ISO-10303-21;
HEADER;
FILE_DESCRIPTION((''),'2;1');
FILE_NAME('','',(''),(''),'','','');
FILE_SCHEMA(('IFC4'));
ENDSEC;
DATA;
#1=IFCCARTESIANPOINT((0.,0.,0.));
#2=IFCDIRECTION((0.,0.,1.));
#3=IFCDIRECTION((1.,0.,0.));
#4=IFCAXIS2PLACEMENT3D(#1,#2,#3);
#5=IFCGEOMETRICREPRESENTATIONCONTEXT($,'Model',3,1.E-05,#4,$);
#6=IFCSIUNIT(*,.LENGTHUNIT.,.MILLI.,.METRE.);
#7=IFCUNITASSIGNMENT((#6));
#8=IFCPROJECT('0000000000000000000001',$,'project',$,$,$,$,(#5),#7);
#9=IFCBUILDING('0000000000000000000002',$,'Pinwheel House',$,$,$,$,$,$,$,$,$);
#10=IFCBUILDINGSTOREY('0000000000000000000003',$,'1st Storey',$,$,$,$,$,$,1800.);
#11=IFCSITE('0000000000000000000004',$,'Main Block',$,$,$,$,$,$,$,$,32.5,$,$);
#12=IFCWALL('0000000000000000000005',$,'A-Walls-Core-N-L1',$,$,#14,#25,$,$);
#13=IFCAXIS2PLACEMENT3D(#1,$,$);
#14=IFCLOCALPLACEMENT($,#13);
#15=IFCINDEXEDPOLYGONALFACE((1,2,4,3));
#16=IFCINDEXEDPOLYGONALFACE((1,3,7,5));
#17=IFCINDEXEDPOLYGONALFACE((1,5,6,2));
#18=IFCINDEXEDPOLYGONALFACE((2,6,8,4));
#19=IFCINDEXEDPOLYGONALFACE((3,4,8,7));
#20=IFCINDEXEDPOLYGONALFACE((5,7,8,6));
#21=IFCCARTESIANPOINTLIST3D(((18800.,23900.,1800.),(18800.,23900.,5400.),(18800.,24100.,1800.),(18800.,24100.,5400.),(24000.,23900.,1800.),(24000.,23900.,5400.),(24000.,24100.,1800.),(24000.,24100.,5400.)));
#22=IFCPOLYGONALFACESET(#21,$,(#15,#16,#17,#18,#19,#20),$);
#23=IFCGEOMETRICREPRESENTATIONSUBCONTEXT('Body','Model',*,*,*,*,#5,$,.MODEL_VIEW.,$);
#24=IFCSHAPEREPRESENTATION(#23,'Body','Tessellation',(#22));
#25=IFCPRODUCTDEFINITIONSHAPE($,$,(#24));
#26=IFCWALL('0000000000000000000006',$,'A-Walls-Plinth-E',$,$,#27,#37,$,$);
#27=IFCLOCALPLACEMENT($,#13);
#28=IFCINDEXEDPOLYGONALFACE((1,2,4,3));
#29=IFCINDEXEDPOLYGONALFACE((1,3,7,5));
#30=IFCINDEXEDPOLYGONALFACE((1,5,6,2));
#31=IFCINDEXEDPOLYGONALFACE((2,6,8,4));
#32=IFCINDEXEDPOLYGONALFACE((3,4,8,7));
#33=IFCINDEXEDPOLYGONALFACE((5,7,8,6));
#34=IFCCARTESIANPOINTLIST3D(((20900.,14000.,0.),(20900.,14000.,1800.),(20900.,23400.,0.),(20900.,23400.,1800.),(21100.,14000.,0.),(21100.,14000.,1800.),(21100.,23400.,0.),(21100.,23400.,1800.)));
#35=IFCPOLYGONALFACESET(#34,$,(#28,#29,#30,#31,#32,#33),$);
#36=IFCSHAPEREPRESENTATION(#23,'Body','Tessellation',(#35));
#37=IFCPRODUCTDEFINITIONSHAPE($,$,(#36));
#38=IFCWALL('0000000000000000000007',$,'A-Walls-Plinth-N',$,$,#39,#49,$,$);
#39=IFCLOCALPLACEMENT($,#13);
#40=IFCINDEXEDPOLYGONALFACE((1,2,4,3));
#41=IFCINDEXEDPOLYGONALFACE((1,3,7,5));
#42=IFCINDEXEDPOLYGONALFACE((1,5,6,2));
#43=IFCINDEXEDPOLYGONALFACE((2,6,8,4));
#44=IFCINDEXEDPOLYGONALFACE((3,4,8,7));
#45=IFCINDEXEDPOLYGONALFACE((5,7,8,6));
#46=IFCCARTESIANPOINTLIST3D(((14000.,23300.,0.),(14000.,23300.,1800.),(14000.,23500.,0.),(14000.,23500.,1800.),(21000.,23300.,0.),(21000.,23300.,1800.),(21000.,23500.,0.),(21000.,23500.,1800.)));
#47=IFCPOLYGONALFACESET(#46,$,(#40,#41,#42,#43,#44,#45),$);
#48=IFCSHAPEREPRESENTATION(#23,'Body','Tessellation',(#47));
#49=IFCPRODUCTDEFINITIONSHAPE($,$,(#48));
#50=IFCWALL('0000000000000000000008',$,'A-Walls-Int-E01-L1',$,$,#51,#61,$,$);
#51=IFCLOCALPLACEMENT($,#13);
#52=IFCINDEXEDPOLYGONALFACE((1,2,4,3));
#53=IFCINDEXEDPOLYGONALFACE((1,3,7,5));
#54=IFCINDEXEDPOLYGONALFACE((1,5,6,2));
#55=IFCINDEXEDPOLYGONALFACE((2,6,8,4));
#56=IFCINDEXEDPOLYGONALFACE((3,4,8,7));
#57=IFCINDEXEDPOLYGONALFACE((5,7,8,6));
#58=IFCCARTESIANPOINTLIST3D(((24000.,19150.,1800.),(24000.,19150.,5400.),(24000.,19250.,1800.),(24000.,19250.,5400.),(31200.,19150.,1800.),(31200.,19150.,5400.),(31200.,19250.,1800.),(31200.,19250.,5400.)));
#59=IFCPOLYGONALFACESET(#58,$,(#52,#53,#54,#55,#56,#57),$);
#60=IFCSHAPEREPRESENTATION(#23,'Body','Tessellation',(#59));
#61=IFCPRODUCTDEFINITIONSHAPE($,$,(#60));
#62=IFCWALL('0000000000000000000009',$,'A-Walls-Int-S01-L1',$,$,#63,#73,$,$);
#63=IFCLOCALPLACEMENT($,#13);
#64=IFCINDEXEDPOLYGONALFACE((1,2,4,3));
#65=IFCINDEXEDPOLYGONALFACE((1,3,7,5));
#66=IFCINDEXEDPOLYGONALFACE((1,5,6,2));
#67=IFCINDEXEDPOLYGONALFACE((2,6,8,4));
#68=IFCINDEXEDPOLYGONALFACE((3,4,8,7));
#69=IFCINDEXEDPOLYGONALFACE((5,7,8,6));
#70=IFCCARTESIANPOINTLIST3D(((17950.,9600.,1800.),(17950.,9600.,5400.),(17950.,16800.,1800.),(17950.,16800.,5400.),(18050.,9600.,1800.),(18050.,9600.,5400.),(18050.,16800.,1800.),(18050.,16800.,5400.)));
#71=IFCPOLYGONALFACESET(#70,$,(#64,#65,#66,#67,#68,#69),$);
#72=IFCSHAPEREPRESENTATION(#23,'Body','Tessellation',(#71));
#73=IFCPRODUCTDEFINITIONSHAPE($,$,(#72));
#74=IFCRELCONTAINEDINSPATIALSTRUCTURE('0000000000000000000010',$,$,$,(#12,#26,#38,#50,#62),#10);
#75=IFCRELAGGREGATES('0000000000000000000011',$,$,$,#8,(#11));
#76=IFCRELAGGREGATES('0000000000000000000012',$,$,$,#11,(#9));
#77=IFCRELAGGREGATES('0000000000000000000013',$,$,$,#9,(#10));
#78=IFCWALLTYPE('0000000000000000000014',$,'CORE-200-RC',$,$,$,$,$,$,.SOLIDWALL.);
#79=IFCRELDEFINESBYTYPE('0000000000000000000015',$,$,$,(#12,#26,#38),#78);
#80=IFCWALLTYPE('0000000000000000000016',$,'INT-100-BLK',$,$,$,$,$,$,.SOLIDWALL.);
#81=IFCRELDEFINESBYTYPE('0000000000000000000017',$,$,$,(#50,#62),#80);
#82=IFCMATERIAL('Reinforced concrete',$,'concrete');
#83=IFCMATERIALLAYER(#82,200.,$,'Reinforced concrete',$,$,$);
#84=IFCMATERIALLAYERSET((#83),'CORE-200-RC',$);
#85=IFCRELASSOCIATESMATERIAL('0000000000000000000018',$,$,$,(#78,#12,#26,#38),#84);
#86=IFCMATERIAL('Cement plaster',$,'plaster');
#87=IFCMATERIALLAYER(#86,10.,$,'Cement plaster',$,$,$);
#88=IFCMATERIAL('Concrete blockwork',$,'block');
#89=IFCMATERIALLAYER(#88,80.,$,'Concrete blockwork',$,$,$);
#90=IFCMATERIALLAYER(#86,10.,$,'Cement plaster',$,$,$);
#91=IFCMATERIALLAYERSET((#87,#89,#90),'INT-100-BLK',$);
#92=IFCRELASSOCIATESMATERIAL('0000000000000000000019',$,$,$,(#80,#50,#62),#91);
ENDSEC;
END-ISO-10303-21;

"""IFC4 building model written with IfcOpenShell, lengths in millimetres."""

from ifc_helpers import new_model, si_unit, frame, origin_with_axes, place, context, subcontext, project, spatial, indexed_curve, outline, extrude, material, layer, layer_set, layer_usage, type_object, element, save


model = new_model("IFC4")

# Units and contexts
model_context = context("Model", 3, precision=1e-05, world=origin_with_axes())
body_context = subcontext(model_context, "Body", "Model", "MODEL_VIEW")
ifc_project = project(units=[si_unit("LENGTHUNIT", "METRE", prefix="MILLI")], contexts=[model_context])

# Site, building, storey
site = spatial("IfcSite", under=ifc_project, Name="Main Block", RefElevation=32.5)
building = spatial("IfcBuilding", under=site, Name="Pinwheel House")
storey = spatial("IfcBuildingStorey", under=building, Name="1st Storey", Elevation=1800.0)

# Walls
ifc_material_1 = material(Name="Reinforced concrete", Category="concrete")
ifc_layer_1 = layer(ifc_material_1, 200.0, Name="Reinforced concrete")
ifc_layer_set_1 = layer_set([ifc_layer_1], Name="CORE-200-RC")
ifc_layer_usage_1 = layer_usage(ifc_layer_set_1, "AXIS2", "POSITIVE", 0.0)
wall_type_1 = type_object("IfcWallType", Name="CORE-200-RC", PredefinedType="SOLIDWALL", material=ifc_layer_set_1)
wall_1_placement = place(None, frame((18800.0, 23900.0, 1800.0), z_axis=(0.0, 0.0, 1.0), x_axis=(1.0, 0.0, 0.0)))
element("IfcWall", 1, at=wall_1_placement, inside=storey, type_object=wall_type_1, material=ifc_layer_usage_1, Name="A-Walls-Core-N-L1", context=body_context, shape_type="SweptSolid", body=[
    extrude(outline(indexed_curve([(0.0, 0.0), (0.0, 200.0), (5200.0, 200.0), (5200.0, 0.0), (0.0, 0.0)], self_intersect=False)), origin_with_axes(), (0.0, 0.0, 1.0), 3600.0),
])
ifc_layer_usage_2 = layer_usage(ifc_layer_set_1, "AXIS2", "POSITIVE", 0.0)
wall_2_placement = place(None, frame((21100.0, 14000.0, 0.0), z_axis=(0.0, 0.0, 1.0), x_axis=(0.0, 1.0, 0.0)))
element("IfcWall", 2, at=wall_2_placement, inside=storey, type_object=wall_type_1, material=ifc_layer_usage_2, Name="A-Walls-Plinth-E", context=body_context, shape_type="SweptSolid", body=[
    extrude(outline(indexed_curve([(0.0, 0.0), (0.0, 200.0), (9400.0, 200.0), (9400.0, 0.0), (0.0, 0.0)], self_intersect=False)), origin_with_axes(), (0.0, 0.0, 1.0), 1800.0),
])
ifc_layer_usage_3 = layer_usage(ifc_layer_set_1, "AXIS2", "POSITIVE", 0.0)
wall_3_placement = place(None, frame((21000.0, 23500.0, 0.0), z_axis=(0.0, 0.0, 1.0), x_axis=(-1.0, 0.0, 0.0)))
element("IfcWall", 3, at=wall_3_placement, inside=storey, type_object=wall_type_1, material=ifc_layer_usage_3, Name="A-Walls-Plinth-N", context=body_context, shape_type="SweptSolid", body=[
    extrude(outline(indexed_curve([(0.0, 0.0), (0.0, 200.0), (7000.0, 200.0), (7000.0, 0.0), (0.0, 0.0)], self_intersect=False)), origin_with_axes(), (0.0, 0.0, 1.0), 1800.0),
])
ifc_material_2 = material(Name="Cement plaster", Category="plaster")
ifc_layer_2 = layer(ifc_material_2, 10.0, Name="Cement plaster")
ifc_material_3 = material(Name="Concrete blockwork", Category="block")
ifc_layer_3 = layer(ifc_material_3, 80.0, Name="Concrete blockwork")
ifc_layer_4 = layer(ifc_material_2, 10.0, Name="Cement plaster")
ifc_layer_set_2 = layer_set([ifc_layer_2, ifc_layer_3, ifc_layer_4], Name="INT-100-BLK")
ifc_layer_usage_4 = layer_usage(ifc_layer_set_2, "AXIS2", "POSITIVE", 0.0)
wall_type_2 = type_object("IfcWallType", Name="INT-100-BLK", PredefinedType="SOLIDWALL", material=ifc_layer_set_2)
wall_4_placement = place(None, frame((24000.0, 19150.0, 1800.0), z_axis=(0.0, 0.0, 1.0), x_axis=(1.0, 0.0, 0.0)))
element("IfcWall", 4, at=wall_4_placement, inside=storey, type_object=wall_type_2, material=ifc_layer_usage_4, Name="A-Walls-Int-E01-L1", context=body_context, shape_type="SweptSolid", body=[
    extrude(outline(indexed_curve([(0.0, 0.0), (0.0, 100.0), (7200.0, 100.0), (7200.0, 0.0), (0.0, 0.0)], self_intersect=False)), origin_with_axes(), (0.0, 0.0, 1.0), 3600.0),
])
ifc_layer_usage_5 = layer_usage(ifc_layer_set_2, "AXIS2", "POSITIVE", 0.0)
wall_5_placement = place(None, frame((18050.0, 9600.0, 1800.0), z_axis=(0.0, 0.0, 1.0), x_axis=(0.0, 1.0, 0.0)))
element("IfcWall", 5, at=wall_5_placement, inside=storey, type_object=wall_type_2, material=ifc_layer_usage_5, Name="A-Walls-Int-S01-L1", context=body_context, shape_type="SweptSolid", body=[
    extrude(outline(indexed_curve([(0.0, 0.0), (0.0, 100.0), (7200.0, 100.0), (7200.0, 0.0), (0.0, 0.0)], self_intersect=False)), origin_with_axes(), (0.0, 0.0, 1.0), 3600.0),
])

save(model, "model.ifc")
